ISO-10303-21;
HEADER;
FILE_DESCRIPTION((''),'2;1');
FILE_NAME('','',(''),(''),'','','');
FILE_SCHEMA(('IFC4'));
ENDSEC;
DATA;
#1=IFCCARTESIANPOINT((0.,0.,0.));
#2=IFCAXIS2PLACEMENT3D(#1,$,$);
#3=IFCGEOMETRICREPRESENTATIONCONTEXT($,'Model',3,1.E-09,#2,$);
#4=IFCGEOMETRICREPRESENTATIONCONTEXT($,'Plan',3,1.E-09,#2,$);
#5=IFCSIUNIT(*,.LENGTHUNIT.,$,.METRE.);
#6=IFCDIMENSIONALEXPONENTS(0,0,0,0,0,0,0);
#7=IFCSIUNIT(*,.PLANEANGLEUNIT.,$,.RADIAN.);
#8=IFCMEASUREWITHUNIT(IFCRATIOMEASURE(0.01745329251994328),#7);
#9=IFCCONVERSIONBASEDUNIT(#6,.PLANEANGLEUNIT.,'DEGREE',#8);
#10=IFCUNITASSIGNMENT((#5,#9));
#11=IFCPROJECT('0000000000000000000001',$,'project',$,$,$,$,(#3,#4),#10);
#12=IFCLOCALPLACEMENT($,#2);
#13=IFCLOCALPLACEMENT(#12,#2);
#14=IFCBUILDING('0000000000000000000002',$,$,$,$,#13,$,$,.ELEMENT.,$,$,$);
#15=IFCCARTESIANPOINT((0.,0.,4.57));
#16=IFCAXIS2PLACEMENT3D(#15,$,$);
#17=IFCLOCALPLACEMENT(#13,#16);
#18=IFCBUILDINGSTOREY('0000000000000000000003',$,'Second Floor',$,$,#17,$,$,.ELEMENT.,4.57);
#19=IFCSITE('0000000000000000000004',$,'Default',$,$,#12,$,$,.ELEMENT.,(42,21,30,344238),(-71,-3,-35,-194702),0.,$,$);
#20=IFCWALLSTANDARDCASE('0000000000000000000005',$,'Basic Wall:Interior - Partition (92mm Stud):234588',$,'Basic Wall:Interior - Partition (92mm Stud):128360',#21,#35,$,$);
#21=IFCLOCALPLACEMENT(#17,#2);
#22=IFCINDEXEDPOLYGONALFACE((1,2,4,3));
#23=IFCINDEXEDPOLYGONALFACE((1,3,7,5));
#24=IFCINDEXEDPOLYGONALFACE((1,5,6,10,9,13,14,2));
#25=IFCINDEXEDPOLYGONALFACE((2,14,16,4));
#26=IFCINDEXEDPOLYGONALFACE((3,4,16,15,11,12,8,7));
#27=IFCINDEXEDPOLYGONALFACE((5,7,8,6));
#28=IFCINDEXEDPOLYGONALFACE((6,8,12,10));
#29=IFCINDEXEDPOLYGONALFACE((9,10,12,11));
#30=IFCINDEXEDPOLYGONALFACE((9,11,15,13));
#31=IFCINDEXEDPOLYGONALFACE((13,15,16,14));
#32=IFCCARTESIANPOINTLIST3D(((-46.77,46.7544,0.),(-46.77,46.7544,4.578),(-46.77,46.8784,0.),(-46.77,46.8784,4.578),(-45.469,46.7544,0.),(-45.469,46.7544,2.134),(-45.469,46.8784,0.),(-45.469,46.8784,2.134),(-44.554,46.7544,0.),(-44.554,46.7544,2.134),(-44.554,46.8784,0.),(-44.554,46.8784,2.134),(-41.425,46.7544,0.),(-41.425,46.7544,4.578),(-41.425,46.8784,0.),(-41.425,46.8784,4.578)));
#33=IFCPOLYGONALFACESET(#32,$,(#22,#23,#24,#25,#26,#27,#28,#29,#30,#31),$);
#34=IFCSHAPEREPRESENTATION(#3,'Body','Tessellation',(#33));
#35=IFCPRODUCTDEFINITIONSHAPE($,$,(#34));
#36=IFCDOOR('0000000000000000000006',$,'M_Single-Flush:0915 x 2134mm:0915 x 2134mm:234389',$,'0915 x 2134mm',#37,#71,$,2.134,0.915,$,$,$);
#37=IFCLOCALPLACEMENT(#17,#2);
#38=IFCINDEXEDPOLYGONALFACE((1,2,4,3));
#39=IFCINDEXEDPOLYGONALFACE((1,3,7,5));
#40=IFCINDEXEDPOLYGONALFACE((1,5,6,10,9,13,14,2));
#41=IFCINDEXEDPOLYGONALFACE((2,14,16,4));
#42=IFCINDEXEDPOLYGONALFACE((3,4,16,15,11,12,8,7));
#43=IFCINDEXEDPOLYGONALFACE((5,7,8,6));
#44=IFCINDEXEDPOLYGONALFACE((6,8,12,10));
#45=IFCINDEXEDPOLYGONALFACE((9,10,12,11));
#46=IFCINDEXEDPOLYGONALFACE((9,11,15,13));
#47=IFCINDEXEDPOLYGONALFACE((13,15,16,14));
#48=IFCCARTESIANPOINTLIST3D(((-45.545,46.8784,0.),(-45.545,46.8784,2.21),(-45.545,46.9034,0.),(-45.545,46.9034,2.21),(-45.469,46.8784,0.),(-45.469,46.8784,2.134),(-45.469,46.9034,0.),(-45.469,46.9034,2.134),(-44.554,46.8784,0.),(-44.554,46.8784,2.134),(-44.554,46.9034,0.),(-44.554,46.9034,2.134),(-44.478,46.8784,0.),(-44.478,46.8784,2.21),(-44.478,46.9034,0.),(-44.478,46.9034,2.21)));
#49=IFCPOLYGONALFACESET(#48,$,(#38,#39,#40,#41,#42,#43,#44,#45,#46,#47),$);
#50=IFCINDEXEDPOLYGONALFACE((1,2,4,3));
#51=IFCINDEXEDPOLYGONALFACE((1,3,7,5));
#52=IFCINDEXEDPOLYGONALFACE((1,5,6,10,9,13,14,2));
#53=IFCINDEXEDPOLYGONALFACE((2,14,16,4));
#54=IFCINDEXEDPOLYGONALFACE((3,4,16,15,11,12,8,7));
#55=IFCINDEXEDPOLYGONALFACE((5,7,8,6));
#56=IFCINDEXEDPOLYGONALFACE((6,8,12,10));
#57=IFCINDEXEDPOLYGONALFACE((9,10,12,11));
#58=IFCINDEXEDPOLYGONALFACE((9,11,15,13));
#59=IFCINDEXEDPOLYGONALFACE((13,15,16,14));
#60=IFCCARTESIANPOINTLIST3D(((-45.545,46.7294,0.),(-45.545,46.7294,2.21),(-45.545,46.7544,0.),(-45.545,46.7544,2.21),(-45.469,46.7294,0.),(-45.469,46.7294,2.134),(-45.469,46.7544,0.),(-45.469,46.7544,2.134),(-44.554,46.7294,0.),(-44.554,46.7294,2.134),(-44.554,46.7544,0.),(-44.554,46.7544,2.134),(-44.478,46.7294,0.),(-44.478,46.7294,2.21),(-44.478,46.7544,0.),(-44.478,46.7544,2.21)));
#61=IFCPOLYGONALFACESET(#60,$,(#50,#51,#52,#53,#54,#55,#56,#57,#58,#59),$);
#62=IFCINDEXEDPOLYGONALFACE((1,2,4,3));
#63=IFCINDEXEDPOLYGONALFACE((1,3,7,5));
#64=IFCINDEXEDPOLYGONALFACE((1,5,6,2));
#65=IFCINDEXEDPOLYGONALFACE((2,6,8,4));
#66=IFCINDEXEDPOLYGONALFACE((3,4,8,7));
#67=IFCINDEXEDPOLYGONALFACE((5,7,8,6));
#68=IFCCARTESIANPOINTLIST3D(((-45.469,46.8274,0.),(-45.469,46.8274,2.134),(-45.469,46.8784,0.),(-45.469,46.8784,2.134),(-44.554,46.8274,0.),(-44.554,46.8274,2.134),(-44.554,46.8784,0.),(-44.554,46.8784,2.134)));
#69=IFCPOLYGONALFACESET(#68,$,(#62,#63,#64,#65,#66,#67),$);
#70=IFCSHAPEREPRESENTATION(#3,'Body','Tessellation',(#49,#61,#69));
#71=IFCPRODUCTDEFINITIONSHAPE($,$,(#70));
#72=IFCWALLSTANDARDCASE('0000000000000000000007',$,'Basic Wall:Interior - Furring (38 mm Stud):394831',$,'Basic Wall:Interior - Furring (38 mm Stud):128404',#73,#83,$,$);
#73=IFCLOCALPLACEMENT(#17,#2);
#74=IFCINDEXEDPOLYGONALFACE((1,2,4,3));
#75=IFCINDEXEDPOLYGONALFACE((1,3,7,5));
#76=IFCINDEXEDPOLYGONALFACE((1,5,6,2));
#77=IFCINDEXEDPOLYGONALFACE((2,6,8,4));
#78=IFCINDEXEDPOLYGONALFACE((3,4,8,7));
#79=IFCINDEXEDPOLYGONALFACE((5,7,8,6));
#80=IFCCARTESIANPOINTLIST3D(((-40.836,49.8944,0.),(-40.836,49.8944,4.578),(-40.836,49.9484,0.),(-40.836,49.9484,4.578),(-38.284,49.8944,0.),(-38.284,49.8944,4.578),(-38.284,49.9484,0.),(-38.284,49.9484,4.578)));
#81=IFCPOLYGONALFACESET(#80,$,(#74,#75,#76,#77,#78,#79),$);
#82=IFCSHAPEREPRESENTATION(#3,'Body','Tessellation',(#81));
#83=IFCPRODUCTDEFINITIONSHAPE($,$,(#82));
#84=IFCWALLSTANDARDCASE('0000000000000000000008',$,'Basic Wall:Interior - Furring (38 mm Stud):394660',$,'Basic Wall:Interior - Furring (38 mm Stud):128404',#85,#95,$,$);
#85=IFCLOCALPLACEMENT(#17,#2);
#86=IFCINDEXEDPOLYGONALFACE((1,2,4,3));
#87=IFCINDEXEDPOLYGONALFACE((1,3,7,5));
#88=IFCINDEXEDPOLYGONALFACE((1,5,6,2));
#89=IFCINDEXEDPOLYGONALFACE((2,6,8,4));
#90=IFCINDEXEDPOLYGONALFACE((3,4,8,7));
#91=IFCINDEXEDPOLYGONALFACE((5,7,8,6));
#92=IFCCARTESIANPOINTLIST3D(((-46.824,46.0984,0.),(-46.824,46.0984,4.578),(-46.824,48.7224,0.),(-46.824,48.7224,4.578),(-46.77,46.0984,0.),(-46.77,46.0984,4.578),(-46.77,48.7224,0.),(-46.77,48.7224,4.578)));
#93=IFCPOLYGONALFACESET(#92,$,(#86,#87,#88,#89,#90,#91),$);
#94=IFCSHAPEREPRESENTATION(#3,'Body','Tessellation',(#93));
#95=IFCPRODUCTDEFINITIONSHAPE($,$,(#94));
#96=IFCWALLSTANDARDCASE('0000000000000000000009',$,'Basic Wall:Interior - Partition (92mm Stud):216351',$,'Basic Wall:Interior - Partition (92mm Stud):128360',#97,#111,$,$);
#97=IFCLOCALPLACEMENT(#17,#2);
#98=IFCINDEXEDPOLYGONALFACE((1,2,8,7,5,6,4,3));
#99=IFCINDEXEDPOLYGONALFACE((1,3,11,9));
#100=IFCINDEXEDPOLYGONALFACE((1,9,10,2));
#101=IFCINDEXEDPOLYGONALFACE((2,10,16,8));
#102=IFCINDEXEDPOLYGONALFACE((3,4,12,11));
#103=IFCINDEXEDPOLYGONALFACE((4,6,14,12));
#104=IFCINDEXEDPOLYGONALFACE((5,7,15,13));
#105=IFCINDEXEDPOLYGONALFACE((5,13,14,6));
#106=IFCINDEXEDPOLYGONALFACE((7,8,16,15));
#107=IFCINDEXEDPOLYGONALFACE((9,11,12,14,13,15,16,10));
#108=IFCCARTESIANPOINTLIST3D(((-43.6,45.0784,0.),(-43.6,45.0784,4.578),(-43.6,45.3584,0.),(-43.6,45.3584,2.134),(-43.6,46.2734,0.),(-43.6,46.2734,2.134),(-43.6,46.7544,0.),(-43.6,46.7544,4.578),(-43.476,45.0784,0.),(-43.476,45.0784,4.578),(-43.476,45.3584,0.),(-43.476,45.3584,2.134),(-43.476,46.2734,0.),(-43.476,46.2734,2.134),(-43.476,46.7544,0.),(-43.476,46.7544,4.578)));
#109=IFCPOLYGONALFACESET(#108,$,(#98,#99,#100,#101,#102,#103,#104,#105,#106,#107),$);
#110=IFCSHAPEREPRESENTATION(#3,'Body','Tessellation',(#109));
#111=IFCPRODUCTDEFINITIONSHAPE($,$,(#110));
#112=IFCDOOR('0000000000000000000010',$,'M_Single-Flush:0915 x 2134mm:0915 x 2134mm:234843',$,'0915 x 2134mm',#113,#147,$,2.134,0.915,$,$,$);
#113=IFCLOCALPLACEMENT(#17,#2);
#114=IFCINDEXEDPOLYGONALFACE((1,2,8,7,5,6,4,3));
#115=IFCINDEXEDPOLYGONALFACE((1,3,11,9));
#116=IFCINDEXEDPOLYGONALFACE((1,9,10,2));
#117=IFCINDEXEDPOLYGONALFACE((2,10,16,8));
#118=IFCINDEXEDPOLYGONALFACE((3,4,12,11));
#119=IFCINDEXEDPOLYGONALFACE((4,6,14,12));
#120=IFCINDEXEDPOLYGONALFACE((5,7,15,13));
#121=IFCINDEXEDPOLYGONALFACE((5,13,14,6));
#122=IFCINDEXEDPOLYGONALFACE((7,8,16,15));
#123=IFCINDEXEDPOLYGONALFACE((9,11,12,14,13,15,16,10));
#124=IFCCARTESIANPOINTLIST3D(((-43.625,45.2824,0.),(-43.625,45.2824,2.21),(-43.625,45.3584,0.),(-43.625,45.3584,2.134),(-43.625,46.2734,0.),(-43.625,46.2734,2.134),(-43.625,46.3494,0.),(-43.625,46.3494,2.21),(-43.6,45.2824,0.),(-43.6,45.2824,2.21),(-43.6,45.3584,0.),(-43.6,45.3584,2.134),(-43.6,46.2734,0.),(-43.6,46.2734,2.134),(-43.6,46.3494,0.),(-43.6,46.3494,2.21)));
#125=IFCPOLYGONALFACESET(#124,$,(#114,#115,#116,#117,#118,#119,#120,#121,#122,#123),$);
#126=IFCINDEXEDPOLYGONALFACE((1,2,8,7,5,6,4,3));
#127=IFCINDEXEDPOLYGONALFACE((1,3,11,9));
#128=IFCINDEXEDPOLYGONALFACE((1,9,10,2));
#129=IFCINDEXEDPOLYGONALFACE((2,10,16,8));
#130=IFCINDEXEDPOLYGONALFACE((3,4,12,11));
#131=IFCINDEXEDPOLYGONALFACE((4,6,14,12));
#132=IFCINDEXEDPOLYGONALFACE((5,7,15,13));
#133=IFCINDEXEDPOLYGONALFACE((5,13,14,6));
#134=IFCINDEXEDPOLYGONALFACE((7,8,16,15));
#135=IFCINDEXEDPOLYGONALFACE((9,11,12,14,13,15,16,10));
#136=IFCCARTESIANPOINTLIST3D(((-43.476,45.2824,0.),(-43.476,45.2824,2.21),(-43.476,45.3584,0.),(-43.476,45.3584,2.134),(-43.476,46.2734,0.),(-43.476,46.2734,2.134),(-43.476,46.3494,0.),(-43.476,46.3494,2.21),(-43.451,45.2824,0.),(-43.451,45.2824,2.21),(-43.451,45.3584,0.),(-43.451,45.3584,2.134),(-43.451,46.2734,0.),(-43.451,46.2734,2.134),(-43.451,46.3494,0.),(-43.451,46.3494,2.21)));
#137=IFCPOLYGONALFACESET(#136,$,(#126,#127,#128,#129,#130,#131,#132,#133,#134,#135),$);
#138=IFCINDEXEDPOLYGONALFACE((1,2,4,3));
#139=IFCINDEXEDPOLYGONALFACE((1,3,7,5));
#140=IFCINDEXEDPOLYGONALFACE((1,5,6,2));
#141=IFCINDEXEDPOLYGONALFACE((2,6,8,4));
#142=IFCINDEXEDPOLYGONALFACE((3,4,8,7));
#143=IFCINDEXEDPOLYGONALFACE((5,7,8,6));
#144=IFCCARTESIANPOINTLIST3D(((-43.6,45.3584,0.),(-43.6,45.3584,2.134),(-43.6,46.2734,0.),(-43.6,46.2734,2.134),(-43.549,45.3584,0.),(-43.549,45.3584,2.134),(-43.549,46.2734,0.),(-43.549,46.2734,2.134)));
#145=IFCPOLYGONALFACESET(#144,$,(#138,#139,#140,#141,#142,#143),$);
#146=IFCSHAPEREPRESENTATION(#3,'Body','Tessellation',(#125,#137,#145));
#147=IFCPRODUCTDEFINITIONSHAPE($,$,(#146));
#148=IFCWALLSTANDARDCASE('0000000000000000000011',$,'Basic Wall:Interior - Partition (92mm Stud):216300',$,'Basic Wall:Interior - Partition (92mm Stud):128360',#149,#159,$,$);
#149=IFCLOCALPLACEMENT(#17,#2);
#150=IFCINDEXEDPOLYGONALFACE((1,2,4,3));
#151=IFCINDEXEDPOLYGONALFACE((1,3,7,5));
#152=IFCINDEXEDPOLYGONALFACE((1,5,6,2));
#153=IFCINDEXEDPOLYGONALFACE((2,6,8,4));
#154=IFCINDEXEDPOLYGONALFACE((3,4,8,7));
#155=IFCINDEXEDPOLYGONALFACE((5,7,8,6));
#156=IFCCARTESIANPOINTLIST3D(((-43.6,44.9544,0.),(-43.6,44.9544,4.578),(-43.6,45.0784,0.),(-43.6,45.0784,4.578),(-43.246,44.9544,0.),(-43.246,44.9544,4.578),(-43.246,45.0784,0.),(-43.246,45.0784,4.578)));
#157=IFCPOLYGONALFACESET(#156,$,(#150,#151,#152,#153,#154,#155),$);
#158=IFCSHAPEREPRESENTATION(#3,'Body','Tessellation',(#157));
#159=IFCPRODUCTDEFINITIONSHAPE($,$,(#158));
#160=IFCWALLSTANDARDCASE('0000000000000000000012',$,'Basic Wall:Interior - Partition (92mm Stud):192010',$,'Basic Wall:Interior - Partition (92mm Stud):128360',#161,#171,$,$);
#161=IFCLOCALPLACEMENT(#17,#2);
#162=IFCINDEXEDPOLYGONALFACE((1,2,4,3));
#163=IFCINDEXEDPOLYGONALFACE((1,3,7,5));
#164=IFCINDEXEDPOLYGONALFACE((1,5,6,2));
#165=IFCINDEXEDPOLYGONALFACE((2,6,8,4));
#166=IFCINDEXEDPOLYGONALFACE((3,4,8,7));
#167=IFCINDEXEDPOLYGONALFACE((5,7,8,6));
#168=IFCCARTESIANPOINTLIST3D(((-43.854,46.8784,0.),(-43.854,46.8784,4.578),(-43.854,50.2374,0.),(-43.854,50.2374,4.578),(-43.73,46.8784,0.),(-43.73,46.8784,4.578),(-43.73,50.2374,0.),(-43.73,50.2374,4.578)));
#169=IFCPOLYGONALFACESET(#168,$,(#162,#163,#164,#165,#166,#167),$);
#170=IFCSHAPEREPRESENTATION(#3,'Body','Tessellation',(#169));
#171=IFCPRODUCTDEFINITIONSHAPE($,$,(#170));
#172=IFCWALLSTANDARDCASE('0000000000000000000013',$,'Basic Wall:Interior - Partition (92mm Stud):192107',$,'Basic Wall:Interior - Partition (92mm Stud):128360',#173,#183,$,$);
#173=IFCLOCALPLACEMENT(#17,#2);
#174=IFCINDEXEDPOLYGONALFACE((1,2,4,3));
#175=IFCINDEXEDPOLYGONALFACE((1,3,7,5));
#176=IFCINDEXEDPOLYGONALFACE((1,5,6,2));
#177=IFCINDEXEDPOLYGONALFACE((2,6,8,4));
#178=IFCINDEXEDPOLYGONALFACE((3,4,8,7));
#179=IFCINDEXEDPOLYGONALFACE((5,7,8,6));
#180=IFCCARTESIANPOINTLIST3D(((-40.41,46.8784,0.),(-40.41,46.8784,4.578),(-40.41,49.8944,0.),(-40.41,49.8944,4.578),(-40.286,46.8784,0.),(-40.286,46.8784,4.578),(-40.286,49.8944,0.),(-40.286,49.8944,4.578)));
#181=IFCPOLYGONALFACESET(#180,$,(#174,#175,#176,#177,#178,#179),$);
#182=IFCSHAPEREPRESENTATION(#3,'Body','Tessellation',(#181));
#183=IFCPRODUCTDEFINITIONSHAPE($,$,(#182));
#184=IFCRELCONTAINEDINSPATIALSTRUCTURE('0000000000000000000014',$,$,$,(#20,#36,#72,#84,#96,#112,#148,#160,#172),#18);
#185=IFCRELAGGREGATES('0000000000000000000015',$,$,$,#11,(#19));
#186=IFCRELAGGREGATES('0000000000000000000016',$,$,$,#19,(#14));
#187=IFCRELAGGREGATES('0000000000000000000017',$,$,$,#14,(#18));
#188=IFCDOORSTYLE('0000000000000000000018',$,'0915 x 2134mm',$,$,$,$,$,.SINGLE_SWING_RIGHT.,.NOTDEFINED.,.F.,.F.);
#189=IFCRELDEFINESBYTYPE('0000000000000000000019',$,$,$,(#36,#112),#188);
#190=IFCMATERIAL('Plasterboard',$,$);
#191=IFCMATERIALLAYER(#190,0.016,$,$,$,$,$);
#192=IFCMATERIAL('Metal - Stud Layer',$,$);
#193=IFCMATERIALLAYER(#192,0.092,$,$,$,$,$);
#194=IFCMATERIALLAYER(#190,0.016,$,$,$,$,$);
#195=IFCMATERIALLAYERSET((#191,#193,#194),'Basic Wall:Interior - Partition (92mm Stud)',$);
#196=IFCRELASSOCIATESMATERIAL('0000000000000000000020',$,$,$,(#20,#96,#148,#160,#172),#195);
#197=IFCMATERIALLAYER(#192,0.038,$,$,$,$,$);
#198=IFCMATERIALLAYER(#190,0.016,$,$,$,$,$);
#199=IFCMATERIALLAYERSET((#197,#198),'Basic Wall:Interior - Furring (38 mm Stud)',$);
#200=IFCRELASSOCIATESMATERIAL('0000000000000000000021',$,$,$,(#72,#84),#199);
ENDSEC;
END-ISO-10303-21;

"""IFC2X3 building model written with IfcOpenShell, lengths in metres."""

from ifc_helpers import new_model, entity, si_unit, converted_unit, frame, frame_2d, origin, origin_2d_with_axis, place, context, project, spatial, polyline, rectangle, outline, extrude, source, transform, mapped, material, layer, layer_set, layer_usage, type_object, type_shapes, element, fill, save


model = new_model("IFC2X3")

# Units and contexts
model_context = context("Model", 3, precision=1e-09, world=origin())
plan_context = context("Plan", 3, precision=1e-09, world=origin())
ifc_project = project(units=[si_unit("LENGTHUNIT", "METRE"), converted_unit("PLANEANGLEUNIT", "DEGREE", entity("IfcRatioMeasure", 0.01745329251994328), si_unit("PLANEANGLEUNIT", "RADIAN"), dimensions=[0, 0, 0, 0, 0, 0, 0])], contexts=[model_context, plan_context])

# Site, building, storey
site_placement = place(None, origin())
site = spatial("IfcSite", under=ifc_project, at=site_placement, Name="Default", CompositionType="ELEMENT", RefLatitude=(42, 21, 30, 344238), RefLongitude=(-71, -3, -35, -194702), RefElevation=0.0)
building_placement = place(site_placement, origin())
building = spatial("IfcBuilding", under=site, at=building_placement, CompositionType="ELEMENT")
storey_placement = place(building_placement, frame((0.0, 0.0, 4.57)))
storey = spatial("IfcBuildingStorey", under=building, at=storey_placement, Name="Second Floor", CompositionType="ELEMENT", Elevation=4.57)

# Shared definitions
ifc_material_1 = material(Name="Plasterboard")
ifc_layer_1 = layer(ifc_material_1, 0.016)
ifc_material_2 = material(Name="Metal - Stud Layer")
ifc_layer_2 = layer(ifc_material_2, 0.092)
ifc_layer_3 = layer(ifc_material_1, 0.016)
ifc_layer_set_1 = layer_set([ifc_layer_1, ifc_layer_2, ifc_layer_3], Name="Basic Wall:Interior - Partition (92mm Stud)")
ifc_layer_usage_1 = layer_usage(ifc_layer_set_1, "AXIS2", "NEGATIVE", 0.062)

# Wall, opening, door
wall_1_placement = place(storey_placement, frame((-41.425, 46.8164, 0.0), z_axis=(0.0, 0.0, 1.0), x_axis=(-1.0, 0.0, 0.0)))
wall_1 = element("IfcWallStandardCase", 1, at=wall_1_placement, inside=storey, material=ifc_layer_usage_1, Name="Basic Wall:Interior - Partition (92mm Stud):234588", ObjectType="Basic Wall:Interior - Partition (92mm Stud):128360", context=model_context, shape_type="SweptSolid", body=[
    extrude(rectangle(XDim=5.345, YDim=0.124, at=frame_2d((2.6725, 0.0), x_axis=(-1.0, 0.0))), origin(), (0.0, 0.0, 1.0), 4.578),
])
opening_1_placement = place(wall_1_placement, frame((4.044, 0.062, 0.0)))
opening_1 = element("IfcOpeningElement", 2, at=opening_1_placement, cuts=wall_1, ObjectType="Opening", context=model_context, shape_type="SweptSolid", body=[
    extrude(rectangle(XDim=0.915, YDim=2.134, at=frame_2d((1.067, 0.4575), x_axis=(0.0, 1.0))), frame((0.0, 0.0, 0.0), z_axis=(0.0, -1.0, 0.0), x_axis=(0.0, 0.0, 1.0)), (0.0, 0.0, 1.0), 0.124),
])
door_style_1 = type_object("IfcDoorStyle", Name="0915 x 2134mm", ConstructionType="NOTDEFINED", OperationType="SINGLE_SWING_RIGHT", ParameterTakesPrecedence=False, Sizeable=False)
shared_shape_1 = source(origin(), model_context, "Body", "SweptSolid", [
    extrude(outline(polyline([(-0.5335, -1.124), (0.5335, -1.124), (0.5335, 1.086), (0.4575, 1.086), (0.4575, -1.048), (-0.4575, -1.048), (-0.4575, 1.086), (-0.5335, 1.086), (-0.5335, -1.124)])), frame((0.4575, 0.124, 1.086), z_axis=(0.0, 1.0, 0.0), x_axis=(1.0, 0.0, 0.0)), (0.0, 0.0, 1.0), 0.025),
    extrude(outline(polyline([(-1.124, -0.5335), (1.086, -0.5335), (1.086, -0.4575), (-1.048, -0.4575), (-1.048, 0.4575), (1.086, 0.4575), (1.086, 0.5335), (-1.124, 0.5335), (-1.124, -0.5335)])), frame((0.4575, -0.025, 1.086), z_axis=(0.0, 1.0, 0.0), x_axis=(0.0, 0.0, -1.0)), (0.0, 0.0, 1.0), 0.025),
    extrude(rectangle(XDim=0.051, YDim=0.915, at=origin_2d_with_axis()), frame((0.4575, 0.0985, 0.0), z_axis=(0.0, 0.0, 1.0), x_axis=(0.0, 1.0, 0.0)), (0.0, 0.0, 1.0), 2.134),
])
type_shapes(door_style_1, [shared_shape_1])
door_1_placement = place(opening_1_placement, frame((0.0, 0.0, 0.0), z_axis=(0.0, 0.0, 1.0), x_axis=(-1.0, 0.0, 0.0)))
door_1 = element("IfcDoor", 3, at=door_1_placement, inside=storey, type_object=door_style_1, Name="M_Single-Flush:0915 x 2134mm:0915 x 2134mm:234389", ObjectType="0915 x 2134mm", OverallHeight=2.134, OverallWidth=0.915, context=model_context, shape_type="MappedRepresentation", body=[
    mapped(shared_shape_1, transform((0.0, 0.0, 0.0), scale=1.0)),
])
fill(opening_1, door_1)

# Walls
ifc_layer_4 = layer(ifc_material_2, 0.038)
ifc_layer_5 = layer(ifc_material_1, 0.016)
ifc_layer_set_2 = layer_set([ifc_layer_4, ifc_layer_5], Name="Basic Wall:Interior - Furring (38 mm Stud)")
ifc_layer_usage_2 = layer_usage(ifc_layer_set_2, "AXIS2", "NEGATIVE", 0.027)
wall_2_placement = place(storey_placement, frame((-40.836, 49.9214, 0.0)))
element("IfcWallStandardCase", 4, at=wall_2_placement, inside=storey, material=ifc_layer_usage_2, Name="Basic Wall:Interior - Furring (38 mm Stud):394831", ObjectType="Basic Wall:Interior - Furring (38 mm Stud):128404", context=model_context, shape_type="SweptSolid", body=[
    extrude(rectangle(XDim=2.552, YDim=0.054, at=frame_2d((1.276, 0.0), x_axis=(-1.0, 0.0))), origin(), (0.0, 0.0, 1.0), 4.578),
])
wall_3_placement = place(storey_placement, frame((-46.797, 46.0984, 0.0), z_axis=(0.0, 0.0, 1.0), x_axis=(0.0, 1.0, 0.0)))
element("IfcWallStandardCase", 5, at=wall_3_placement, inside=storey, material=ifc_layer_usage_2, Name="Basic Wall:Interior - Furring (38 mm Stud):394660", ObjectType="Basic Wall:Interior - Furring (38 mm Stud):128404", context=model_context, shape_type="SweptSolid", body=[
    extrude(rectangle(XDim=2.624, YDim=0.054, at=frame_2d((1.312, 0.0), x_axis=(-1.0, 0.0))), origin(), (0.0, 0.0, 1.0), 4.578),
])

# Wall, opening, door
wall_4_placement = place(storey_placement, frame((-43.538, 45.0784, 0.0), z_axis=(0.0, 0.0, 1.0), x_axis=(0.0, 1.0, 0.0)))
wall_4 = element("IfcWallStandardCase", 6, at=wall_4_placement, inside=storey, material=ifc_layer_usage_1, Name="Basic Wall:Interior - Partition (92mm Stud):216351", ObjectType="Basic Wall:Interior - Partition (92mm Stud):128360", context=model_context, shape_type="SweptSolid", body=[
    extrude(rectangle(XDim=1.676, YDim=0.124, at=frame_2d((0.838, 0.0), x_axis=(-1.0, 0.0))), origin(), (0.0, 0.0, 1.0), 4.578),
])
opening_2_placement = place(wall_4_placement, frame((0.28, -0.062, 0.0)))
opening_2 = element("IfcOpeningElement", 7, at=opening_2_placement, cuts=wall_4, ObjectType="Opening", context=model_context, shape_type="SweptSolid", body=[
    extrude(rectangle(XDim=0.915, YDim=2.134, at=frame_2d((1.067, 0.4575), x_axis=(0.0, 1.0))), frame((0.0, 0.0, 0.0), z_axis=(0.0, 1.0, 0.0), x_axis=(0.0, 0.0, 1.0)), (0.0, 0.0, 1.0), 0.124),
])
door_2_placement = place(opening_2_placement, origin())
door_2 = element("IfcDoor", 8, at=door_2_placement, inside=storey, type_object=door_style_1, Name="M_Single-Flush:0915 x 2134mm:0915 x 2134mm:234843", ObjectType="0915 x 2134mm", OverallHeight=2.134, OverallWidth=0.915, context=model_context, shape_type="MappedRepresentation", body=[
    mapped(shared_shape_1, transform((0.0, 0.0, 0.0), scale=1.0)),
])
fill(opening_2, door_2)

# Walls
wall_5_placement = place(storey_placement, frame((-43.246, 45.0164, 0.0), z_axis=(0.0, 0.0, 1.0), x_axis=(-1.0, 0.0, 0.0)))
element("IfcWallStandardCase", 9, at=wall_5_placement, inside=storey, material=ifc_layer_usage_1, Name="Basic Wall:Interior - Partition (92mm Stud):216300", ObjectType="Basic Wall:Interior - Partition (92mm Stud):128360", context=model_context, shape_type="SweptSolid", body=[
    extrude(rectangle(XDim=0.354, YDim=0.124, at=frame_2d((0.177, 0.0), x_axis=(-1.0, 0.0))), origin(), (0.0, 0.0, 1.0), 4.578),
])
wall_6_placement = place(storey_placement, frame((-43.792, 50.2374, 0.0), z_axis=(0.0, 0.0, 1.0), x_axis=(0.0, -1.0, 0.0)))
element("IfcWallStandardCase", 10, at=wall_6_placement, inside=storey, material=ifc_layer_usage_1, Name="Basic Wall:Interior - Partition (92mm Stud):192010", ObjectType="Basic Wall:Interior - Partition (92mm Stud):128360", context=model_context, shape_type="SweptSolid", body=[
    extrude(rectangle(XDim=3.359, YDim=0.124, at=frame_2d((1.6795, 0.0), x_axis=(-1.0, 0.0))), origin(), (0.0, 0.0, 1.0), 4.578),
])
wall_7_placement = place(storey_placement, frame((-40.348, 46.8784, 0.0), z_axis=(0.0, 0.0, 1.0), x_axis=(0.0, 1.0, 0.0)))
element("IfcWallStandardCase", 11, at=wall_7_placement, inside=storey, material=ifc_layer_usage_1, Name="Basic Wall:Interior - Partition (92mm Stud):192107", ObjectType="Basic Wall:Interior - Partition (92mm Stud):128360", context=model_context, shape_type="SweptSolid", body=[
    extrude(rectangle(XDim=3.016, YDim=0.124, at=frame_2d((1.508, 0.0), x_axis=(-1.0, 0.0))), origin(), (0.0, 0.0, 1.0), 4.578),
])

save(model, "model.ifc")
